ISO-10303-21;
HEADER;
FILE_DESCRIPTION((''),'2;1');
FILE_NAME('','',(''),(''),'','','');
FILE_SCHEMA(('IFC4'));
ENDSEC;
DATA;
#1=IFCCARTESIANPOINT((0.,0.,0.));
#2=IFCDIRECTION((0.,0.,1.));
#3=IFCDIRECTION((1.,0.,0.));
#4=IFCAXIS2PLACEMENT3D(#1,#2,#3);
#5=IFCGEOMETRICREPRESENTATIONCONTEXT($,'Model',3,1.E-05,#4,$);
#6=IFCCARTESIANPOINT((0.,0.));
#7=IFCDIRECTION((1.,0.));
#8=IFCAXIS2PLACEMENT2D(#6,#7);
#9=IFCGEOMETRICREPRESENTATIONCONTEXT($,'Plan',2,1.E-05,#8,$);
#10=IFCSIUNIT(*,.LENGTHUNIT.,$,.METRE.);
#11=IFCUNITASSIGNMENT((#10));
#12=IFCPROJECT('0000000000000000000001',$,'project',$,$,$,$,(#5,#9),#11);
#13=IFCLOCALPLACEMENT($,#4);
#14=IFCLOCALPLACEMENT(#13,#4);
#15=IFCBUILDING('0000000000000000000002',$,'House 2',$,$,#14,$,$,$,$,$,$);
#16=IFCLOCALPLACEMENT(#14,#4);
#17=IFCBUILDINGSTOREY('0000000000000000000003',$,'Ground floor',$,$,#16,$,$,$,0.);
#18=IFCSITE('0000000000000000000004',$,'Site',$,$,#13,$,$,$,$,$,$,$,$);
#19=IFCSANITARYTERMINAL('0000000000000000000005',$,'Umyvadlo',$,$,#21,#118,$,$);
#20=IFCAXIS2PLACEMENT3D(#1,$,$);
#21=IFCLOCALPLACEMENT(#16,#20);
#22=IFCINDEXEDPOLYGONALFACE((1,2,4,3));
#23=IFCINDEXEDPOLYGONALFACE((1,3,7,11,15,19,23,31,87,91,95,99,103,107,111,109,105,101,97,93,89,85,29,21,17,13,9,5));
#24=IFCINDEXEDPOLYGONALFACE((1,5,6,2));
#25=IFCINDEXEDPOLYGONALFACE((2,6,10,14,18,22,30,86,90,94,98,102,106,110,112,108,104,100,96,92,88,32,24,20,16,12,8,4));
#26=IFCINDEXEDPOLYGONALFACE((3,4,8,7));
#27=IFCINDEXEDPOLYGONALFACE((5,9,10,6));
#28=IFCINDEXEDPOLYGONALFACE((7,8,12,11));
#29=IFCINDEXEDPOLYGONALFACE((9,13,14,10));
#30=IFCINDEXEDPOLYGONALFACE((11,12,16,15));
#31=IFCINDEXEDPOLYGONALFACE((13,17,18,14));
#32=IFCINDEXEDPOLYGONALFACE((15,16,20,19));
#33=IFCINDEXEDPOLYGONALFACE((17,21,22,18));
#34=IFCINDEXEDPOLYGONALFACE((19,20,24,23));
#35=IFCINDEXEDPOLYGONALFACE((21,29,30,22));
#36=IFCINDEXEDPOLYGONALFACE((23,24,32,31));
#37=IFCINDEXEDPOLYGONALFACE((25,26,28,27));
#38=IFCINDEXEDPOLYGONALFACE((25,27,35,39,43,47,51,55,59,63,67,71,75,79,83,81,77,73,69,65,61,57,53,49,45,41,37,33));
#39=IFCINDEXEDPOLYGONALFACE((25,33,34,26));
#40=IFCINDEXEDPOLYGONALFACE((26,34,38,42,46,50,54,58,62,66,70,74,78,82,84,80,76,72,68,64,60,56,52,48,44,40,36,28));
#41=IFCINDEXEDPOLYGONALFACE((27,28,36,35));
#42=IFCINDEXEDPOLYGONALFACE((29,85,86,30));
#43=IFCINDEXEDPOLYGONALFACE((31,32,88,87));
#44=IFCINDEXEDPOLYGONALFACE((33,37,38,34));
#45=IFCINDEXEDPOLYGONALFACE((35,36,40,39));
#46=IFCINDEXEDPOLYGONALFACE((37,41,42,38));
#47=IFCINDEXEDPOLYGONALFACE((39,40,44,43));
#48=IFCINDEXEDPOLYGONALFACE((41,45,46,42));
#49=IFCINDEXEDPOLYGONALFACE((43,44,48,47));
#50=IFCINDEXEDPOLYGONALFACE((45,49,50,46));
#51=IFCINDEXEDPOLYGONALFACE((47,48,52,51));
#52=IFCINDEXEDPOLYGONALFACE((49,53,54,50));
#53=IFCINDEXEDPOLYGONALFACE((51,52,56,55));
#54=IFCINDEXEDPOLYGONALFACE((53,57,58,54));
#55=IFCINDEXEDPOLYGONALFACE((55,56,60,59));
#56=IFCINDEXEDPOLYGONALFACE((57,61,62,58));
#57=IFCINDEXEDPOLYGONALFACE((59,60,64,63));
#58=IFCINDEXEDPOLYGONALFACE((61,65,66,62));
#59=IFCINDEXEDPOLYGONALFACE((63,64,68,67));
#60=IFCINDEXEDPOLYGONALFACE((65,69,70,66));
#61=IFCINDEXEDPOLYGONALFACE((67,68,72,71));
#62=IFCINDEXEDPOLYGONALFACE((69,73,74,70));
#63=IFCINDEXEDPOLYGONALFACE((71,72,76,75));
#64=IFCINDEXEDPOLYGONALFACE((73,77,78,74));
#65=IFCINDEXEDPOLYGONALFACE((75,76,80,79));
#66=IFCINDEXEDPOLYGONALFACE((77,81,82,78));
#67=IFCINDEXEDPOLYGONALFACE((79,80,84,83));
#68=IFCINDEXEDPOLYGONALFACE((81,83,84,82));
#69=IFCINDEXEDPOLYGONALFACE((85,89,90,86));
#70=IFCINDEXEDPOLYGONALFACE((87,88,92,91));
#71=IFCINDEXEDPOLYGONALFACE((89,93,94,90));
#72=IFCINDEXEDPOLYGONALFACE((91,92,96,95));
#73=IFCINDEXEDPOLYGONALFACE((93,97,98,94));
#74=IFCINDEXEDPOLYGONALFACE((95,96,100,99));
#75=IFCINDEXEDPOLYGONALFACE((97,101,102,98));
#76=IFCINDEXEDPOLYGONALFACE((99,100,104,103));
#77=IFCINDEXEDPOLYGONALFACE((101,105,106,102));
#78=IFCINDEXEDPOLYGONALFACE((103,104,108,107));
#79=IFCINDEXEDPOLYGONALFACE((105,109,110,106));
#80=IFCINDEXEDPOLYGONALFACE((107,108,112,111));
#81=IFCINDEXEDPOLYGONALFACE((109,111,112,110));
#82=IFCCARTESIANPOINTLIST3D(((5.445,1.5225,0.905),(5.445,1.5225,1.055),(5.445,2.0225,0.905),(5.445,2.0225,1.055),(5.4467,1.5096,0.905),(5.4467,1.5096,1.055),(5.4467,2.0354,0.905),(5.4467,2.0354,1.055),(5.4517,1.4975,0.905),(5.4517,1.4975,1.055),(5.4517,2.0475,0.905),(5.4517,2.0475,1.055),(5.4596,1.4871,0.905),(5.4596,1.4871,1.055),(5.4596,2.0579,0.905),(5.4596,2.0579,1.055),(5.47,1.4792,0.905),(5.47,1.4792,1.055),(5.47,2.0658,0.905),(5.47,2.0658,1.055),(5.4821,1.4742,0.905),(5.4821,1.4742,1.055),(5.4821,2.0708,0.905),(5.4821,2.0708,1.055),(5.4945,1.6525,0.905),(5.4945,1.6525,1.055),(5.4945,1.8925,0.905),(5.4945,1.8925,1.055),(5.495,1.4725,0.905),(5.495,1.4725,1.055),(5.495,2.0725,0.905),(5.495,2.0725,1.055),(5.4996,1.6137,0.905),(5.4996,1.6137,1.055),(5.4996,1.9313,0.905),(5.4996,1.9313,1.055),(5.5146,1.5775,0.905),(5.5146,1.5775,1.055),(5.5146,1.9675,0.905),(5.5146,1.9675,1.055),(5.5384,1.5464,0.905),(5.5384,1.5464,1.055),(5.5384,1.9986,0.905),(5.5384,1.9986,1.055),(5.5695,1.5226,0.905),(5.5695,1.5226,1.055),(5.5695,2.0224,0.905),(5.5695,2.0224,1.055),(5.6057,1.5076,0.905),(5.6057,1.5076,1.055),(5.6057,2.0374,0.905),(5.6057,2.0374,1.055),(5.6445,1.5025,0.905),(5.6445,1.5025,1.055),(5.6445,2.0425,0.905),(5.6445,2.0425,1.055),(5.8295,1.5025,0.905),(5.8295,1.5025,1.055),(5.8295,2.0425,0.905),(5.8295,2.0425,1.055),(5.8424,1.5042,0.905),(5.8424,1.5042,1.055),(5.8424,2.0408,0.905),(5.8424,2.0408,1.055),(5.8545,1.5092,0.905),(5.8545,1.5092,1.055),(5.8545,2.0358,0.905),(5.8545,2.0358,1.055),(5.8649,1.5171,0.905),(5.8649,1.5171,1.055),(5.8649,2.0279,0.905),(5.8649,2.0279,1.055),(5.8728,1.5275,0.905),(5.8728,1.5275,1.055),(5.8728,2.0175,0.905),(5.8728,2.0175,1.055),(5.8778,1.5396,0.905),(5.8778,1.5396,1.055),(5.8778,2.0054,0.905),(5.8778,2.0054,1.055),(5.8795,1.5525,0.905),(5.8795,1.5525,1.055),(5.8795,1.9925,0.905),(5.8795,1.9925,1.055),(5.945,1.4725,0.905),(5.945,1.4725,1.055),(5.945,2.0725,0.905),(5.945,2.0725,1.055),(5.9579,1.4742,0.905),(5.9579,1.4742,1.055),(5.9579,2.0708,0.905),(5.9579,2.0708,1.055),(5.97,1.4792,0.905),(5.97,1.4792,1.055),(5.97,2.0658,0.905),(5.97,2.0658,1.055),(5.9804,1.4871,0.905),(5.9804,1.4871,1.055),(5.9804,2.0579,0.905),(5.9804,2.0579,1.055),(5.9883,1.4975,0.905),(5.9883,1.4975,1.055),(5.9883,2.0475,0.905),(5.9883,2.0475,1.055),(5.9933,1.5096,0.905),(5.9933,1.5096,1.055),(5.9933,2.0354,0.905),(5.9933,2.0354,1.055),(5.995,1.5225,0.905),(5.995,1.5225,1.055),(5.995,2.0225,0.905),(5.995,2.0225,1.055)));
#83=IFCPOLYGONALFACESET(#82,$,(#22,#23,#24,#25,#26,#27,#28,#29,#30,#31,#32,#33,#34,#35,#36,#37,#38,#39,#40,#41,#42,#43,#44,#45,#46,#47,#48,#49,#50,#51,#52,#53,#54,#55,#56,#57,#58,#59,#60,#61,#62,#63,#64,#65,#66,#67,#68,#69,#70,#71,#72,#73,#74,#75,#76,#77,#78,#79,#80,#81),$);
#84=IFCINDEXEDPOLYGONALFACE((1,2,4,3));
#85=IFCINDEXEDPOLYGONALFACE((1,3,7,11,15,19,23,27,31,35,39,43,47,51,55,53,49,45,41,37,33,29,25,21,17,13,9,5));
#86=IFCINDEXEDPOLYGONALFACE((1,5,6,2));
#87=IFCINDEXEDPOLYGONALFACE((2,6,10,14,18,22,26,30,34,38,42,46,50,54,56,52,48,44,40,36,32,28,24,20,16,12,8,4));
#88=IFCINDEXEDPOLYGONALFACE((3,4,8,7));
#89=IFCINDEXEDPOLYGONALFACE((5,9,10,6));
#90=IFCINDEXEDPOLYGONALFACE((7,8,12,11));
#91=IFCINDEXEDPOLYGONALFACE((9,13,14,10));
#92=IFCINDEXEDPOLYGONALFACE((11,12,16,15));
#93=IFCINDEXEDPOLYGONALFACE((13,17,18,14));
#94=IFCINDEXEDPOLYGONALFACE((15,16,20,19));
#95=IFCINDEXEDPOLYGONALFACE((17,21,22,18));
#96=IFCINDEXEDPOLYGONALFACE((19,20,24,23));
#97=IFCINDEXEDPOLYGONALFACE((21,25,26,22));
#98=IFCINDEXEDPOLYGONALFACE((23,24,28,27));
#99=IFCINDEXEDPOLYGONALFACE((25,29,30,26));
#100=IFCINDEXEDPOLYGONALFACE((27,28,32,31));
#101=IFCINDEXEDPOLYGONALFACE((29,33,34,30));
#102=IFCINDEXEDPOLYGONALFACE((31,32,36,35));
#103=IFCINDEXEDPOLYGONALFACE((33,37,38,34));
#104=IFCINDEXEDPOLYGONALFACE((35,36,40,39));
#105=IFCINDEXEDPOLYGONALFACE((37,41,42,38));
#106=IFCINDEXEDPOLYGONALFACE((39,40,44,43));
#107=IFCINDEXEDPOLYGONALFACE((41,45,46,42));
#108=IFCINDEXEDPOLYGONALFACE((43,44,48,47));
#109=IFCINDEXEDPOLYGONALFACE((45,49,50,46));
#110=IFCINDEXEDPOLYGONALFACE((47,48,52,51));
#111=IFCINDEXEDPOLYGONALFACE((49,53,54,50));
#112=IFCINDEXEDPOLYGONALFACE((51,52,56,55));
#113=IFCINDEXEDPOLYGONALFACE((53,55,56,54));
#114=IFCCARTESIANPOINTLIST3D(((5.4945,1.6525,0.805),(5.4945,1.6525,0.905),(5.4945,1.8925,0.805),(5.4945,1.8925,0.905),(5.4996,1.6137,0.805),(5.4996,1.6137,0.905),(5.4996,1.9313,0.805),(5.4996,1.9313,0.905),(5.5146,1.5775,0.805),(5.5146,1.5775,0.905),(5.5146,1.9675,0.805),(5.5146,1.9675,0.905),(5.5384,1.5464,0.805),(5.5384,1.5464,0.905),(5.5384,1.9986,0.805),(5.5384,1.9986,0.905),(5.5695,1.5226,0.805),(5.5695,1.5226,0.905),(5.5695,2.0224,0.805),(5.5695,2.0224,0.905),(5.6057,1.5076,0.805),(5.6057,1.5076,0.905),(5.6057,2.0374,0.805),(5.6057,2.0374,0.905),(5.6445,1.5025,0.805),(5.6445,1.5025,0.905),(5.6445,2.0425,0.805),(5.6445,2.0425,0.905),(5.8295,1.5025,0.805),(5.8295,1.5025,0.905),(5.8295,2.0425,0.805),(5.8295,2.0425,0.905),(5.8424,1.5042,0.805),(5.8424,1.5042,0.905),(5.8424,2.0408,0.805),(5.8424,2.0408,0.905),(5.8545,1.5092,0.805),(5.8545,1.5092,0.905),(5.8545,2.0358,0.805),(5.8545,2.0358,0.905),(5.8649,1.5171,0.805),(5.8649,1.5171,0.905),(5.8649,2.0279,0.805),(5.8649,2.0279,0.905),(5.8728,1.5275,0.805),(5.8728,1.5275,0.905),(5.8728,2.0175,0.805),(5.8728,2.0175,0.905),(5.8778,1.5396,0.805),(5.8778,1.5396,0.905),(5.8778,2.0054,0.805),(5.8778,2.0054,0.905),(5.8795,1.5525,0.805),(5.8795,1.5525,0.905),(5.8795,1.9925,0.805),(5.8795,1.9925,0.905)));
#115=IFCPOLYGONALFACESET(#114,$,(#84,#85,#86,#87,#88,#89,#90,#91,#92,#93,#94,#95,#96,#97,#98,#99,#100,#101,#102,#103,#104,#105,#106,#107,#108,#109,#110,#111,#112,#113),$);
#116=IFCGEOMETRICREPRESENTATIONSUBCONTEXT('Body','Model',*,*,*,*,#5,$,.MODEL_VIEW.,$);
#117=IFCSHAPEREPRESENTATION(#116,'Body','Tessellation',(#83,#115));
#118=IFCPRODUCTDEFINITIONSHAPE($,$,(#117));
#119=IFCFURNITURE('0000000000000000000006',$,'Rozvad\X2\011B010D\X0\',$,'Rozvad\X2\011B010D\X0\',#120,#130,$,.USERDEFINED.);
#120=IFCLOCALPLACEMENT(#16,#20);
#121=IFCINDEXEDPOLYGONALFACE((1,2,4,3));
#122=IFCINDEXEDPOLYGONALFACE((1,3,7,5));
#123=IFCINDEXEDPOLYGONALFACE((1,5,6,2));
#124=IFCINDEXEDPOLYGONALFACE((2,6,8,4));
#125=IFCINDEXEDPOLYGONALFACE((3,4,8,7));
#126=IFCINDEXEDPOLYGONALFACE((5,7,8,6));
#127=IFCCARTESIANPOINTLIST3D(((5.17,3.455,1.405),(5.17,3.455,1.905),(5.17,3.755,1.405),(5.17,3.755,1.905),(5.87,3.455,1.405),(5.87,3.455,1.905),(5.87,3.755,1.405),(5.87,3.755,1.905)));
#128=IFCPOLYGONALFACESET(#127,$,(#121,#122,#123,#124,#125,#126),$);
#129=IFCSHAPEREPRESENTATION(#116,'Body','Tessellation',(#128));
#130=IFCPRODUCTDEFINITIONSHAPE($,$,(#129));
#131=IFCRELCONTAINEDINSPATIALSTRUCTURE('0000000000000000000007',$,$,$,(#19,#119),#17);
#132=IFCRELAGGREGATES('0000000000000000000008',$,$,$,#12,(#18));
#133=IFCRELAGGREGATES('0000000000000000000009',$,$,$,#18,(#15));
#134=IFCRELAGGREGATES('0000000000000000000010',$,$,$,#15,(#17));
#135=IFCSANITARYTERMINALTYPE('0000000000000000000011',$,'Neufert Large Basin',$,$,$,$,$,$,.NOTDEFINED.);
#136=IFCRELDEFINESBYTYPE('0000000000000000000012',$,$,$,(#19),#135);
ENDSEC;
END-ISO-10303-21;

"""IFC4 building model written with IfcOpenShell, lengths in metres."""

from ifc_helpers import new_model, entity, si_unit, frame, origin_with_axes, origin_2d_with_axis, place, context, subcontext, project, spatial, indexed_curve, outline, extrude, shape, source, transform, mapped, type_object, type_shapes, element, save


model = new_model("IFC4")

# Units and contexts
model_context = context("Model", 3, precision=1e-05, world=origin_with_axes())
plan_context = context("Plan", 2, precision=1e-05, world=origin_2d_with_axis())
body_context_1 = subcontext(model_context, "Body", "Model", "MODEL_VIEW")
body_context_2 = subcontext(plan_context, "Body", "Plan", "PLAN_VIEW")
ifc_project = project(units=[si_unit("LENGTHUNIT", "METRE")], contexts=[model_context, plan_context])

# Site, building, storey
site_placement = place(None, origin_with_axes())
site = spatial("IfcSite", under=ifc_project, at=site_placement, Name="Site")
building_placement = place(site_placement, origin_with_axes())
building = spatial("IfcBuilding", under=site, at=building_placement, Name="House 2")
storey_placement = place(building_placement, origin_with_axes())
storey = spatial("IfcBuildingStorey", under=building, at=storey_placement, Name="Ground floor", Elevation=0.0)

# Sanitary terminal
sanitary_terminal_type_1 = type_object("IfcSanitaryTerminalType", Name="Neufert Large Basin", PredefinedType="NOTDEFINED")
shared_indexed_poly_curve_1 = entity("IfcIndexedPolyCurve", entity("IfcCartesianPointList2D", [[0.03, 0.1995], [0.0739, 0.0934], [0.18, 0.0495], [0.42, 0.0495], [0.5261, 0.0934], [0.57, 0.1995], [0.57, 0.3845], [0.5554, 0.4199], [0.52, 0.4345], [0.08, 0.4345], [0.0446, 0.4199], [0.03, 0.3845]]), [entity("IfcLineIndex", [12, 1]), entity("IfcArcIndex", [1, 2, 3]), entity("IfcLineIndex", [3, 4]), entity("IfcArcIndex", [4, 5, 6]), entity("IfcLineIndex", [6, 7]), entity("IfcArcIndex", [7, 8, 9]), entity("IfcLineIndex", [9, 10]), entity("IfcArcIndex", [10, 11, 12])])
shared_shape_1 = source(origin_with_axes(), body_context_1, "Body", "SweptSolid", [
    entity("IfcExtrudedAreaSolid", entity("IfcArbitraryProfileDefWithVoids", "AREA", None, entity("IfcIndexedPolyCurve", entity("IfcCartesianPointList2D", [[0.0, 0.05], [0.0146, 0.0146], [0.05, 0.0], [0.55, 0.0], [0.5854, 0.0146], [0.6, 0.05], [0.6, 0.5], [0.5854, 0.5354], [0.55, 0.55], [0.05, 0.55], [0.0146, 0.5354], [0.0, 0.5]]), [entity("IfcLineIndex", [12, 1]), entity("IfcArcIndex", [1, 2, 3]), entity("IfcLineIndex", [3, 4]), entity("IfcArcIndex", [4, 5, 6]), entity("IfcLineIndex", [6, 7]), entity("IfcArcIndex", [7, 8, 9]), entity("IfcLineIndex", [9, 10]), entity("IfcArcIndex", [10, 11, 12])]), [shared_indexed_poly_curve_1]), entity("IfcAxis2Placement3D", entity("IfcCartesianPoint", [-0.3, -0.55, 0.1]), entity("IfcDirection", [0.0, 0.0, 1.0]), entity("IfcDirection", [1.0, 0.0, 0.0])), entity("IfcDirection", [0.0, 0.0, 1.0]), 0.15),
    entity("IfcExtrudedAreaSolid", entity("IfcArbitraryClosedProfileDef", "AREA", None, shared_indexed_poly_curve_1), entity("IfcAxis2Placement3D", entity("IfcCartesianPoint", [-0.3, -0.55, 0.0]), entity("IfcDirection", [0.0, 0.0, 1.0]), entity("IfcDirection", [1.0, 0.0, 0.0])), entity("IfcDirection", [0.0, 0.0, 1.0]), 0.1),
])
shared_shape_2 = source(origin_with_axes(), body_context_2, "Body", "Curve2D", [
    entity("IfcIndexedPolyCurve", entity("IfcCartesianPointList2D", [[-0.3, -0.5], [-0.2854, -0.5354], [-0.25, -0.55], [0.25, -0.55], [0.2854, -0.5354], [0.3, -0.5], [0.3, -0.05], [0.2854, -0.0146], [0.25, 0.0], [-0.25, 0.0], [-0.2854, -0.0146], [-0.3, -0.05]]), [entity("IfcLineIndex", [12, 1]), entity("IfcArcIndex", [1, 2, 3]), entity("IfcLineIndex", [3, 4]), entity("IfcArcIndex", [4, 5, 6]), entity("IfcLineIndex", [6, 7]), entity("IfcArcIndex", [7, 8, 9]), entity("IfcLineIndex", [9, 10]), entity("IfcArcIndex", [10, 11, 12]), entity("IfcLineIndex", [12, 1])]),
    entity("IfcIndexedPolyCurve", entity("IfcCartesianPointList2D", [[-0.27, -0.3505], [-0.2261, -0.4566], [-0.12, -0.5005], [0.12, -0.5005], [0.2261, -0.4566], [0.27, -0.3505], [0.27, -0.1655], [0.2554, -0.1301], [0.22, -0.1155], [-0.22, -0.1155], [-0.2554, -0.1301], [-0.27, -0.1655]]), [entity("IfcLineIndex", [12, 1]), entity("IfcArcIndex", [1, 2, 3]), entity("IfcLineIndex", [3, 4]), entity("IfcArcIndex", [4, 5, 6]), entity("IfcLineIndex", [6, 7]), entity("IfcArcIndex", [7, 8, 9]), entity("IfcLineIndex", [9, 10]), entity("IfcArcIndex", [10, 11, 12]), entity("IfcLineIndex", [12, 1])]),
    entity("IfcIndexedPolyCurve", entity("IfcCartesianPointList2D", [[0.0, -0.0413], [0.0, -0.1613]])),
])
type_shapes(sanitary_terminal_type_1, [shared_shape_1, shared_shape_2])
sanitary_terminal_1_placement = place(storey_placement, frame((5.995, 1.7725, 0.805), z_axis=(0.0, 0.0, 1.0), x_axis=(0.0, -1.0, 0.0)))
element("IfcSanitaryTerminal", 1, at=sanitary_terminal_1_placement, inside=storey, type_object=sanitary_terminal_type_1, Name="Umyvadlo", shapes=[
    shape(body_context_1, "Body", "MappedRepresentation", [mapped(shared_shape_1, transform((0.0, 0.0, 0.0), x_axis=(1.0, 0.0, 0.0), y_axis=(0.0, 1.0, 0.0), z_axis=(0.0, 0.0, 1.0), scale=1.0))]),
    shape(body_context_2, "Body", "MappedRepresentation", [mapped(shared_shape_2, transform((0.0, 0.0, 0.0), x_axis=(1.0, 0.0, 0.0), y_axis=(0.0, 1.0, 0.0), z_axis=(0.0, 0.0, 1.0), scale=1.0))]),
])

# Furniture
furniture_placement = place(storey_placement, frame((5.52, 3.605, 1.405), z_axis=(0.0, 0.0, 1.0), x_axis=(1.0, 0.0, 0.0)))
element("IfcFurniture", 2, at=furniture_placement, inside=storey, Name="Rozvaděč", ObjectType="Rozvaděč", PredefinedType="USERDEFINED", shapes=[
    shape(body_context_1, "Body", "SweptSolid", [extrude(outline(indexed_curve([(-0.35, -0.15), (0.35, -0.15), (0.35, 0.15), (-0.35, 0.15)])), None, (0.0, 0.0, 1.0), 0.5)]),
    shape(body_context_2, "Body", "Curve2D", [entity("IfcIndexedPolyCurve", entity("IfcCartesianPointList2D", [[-0.35, -0.15], [0.35, -0.15], [0.35, 0.15], [-0.35, 0.15], [-0.35, -0.15]]), None, False)]),
])

save(model, "model.ifc")
